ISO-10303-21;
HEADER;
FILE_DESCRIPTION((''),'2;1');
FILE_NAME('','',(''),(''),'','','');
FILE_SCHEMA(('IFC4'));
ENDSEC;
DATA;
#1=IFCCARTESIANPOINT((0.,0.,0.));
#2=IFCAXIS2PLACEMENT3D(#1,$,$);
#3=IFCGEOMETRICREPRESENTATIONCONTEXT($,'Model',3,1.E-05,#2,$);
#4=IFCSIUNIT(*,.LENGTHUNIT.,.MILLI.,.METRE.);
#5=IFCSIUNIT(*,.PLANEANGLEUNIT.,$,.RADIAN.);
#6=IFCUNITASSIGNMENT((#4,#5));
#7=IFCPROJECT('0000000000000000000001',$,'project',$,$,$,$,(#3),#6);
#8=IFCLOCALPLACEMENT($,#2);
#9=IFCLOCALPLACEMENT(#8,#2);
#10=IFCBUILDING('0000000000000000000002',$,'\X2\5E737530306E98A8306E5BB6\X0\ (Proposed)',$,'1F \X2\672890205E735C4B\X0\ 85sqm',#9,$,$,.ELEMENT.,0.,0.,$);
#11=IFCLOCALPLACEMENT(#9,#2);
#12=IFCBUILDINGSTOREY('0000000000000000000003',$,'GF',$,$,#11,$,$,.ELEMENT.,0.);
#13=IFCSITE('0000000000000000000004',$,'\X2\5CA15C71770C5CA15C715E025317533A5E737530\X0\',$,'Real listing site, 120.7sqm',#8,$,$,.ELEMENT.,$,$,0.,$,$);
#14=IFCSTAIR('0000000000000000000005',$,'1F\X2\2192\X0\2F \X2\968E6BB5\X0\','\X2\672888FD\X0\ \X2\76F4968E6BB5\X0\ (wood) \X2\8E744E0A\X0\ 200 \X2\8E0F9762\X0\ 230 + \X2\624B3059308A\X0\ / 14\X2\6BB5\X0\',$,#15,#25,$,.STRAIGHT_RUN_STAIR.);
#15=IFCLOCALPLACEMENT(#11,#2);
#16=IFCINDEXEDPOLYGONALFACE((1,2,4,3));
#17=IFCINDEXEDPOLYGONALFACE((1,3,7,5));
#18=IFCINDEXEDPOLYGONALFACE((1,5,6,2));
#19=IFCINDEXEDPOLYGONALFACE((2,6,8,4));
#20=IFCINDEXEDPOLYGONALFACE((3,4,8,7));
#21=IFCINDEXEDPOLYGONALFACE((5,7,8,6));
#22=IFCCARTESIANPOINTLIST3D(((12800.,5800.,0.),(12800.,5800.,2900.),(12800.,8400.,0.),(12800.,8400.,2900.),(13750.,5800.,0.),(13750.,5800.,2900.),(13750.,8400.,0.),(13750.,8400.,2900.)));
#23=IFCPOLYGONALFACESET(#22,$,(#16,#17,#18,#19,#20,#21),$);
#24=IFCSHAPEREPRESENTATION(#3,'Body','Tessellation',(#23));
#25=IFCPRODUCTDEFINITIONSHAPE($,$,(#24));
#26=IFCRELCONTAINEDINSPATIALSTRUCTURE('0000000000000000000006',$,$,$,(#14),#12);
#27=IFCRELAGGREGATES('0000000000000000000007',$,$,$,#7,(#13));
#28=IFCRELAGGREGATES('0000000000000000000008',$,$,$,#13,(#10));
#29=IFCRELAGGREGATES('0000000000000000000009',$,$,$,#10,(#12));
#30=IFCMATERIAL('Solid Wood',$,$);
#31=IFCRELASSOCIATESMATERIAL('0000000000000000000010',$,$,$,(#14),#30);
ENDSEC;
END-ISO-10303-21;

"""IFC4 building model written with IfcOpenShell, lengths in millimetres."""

from ifc_helpers import new_model, si_unit, frame, frame_2d, origin, place, context, project, spatial, rectangle, extrude, material, element, save


model = new_model("IFC4")

# Units and contexts
model_context = context("Model", 3, precision=1e-05, world=origin())
ifc_project = project(units=[si_unit("LENGTHUNIT", "METRE", prefix="MILLI"), si_unit("PLANEANGLEUNIT", "RADIAN")], contexts=[model_context])

# Site, building, storey
site_placement = place(None, origin())
site = spatial("IfcSite", under=ifc_project, at=site_placement, Name="岡山県岡山市北区平田", ObjectType="Real listing site, 120.7sqm", CompositionType="ELEMENT", RefElevation=0.0)
building_placement = place(site_placement, origin())
building = spatial("IfcBuilding", under=site, at=building_placement, Name="平田の風の家 (Proposed)", ObjectType="1F 木造平屋 85sqm", CompositionType="ELEMENT", ElevationOfRefHeight=0.0, ElevationOfTerrain=0.0)
storey_placement = place(building_placement, origin())
storey = spatial("IfcBuildingStorey", under=building, at=storey_placement, Name="GF", CompositionType="ELEMENT", Elevation=0.0)

# Shared definitions
ifc_material_1 = material(Name="Solid Wood")

# Stair
stair_placement = place(storey_placement, frame((6400.0, 2900.0, 0.0)))
element("IfcStair", 1, at=stair_placement, inside=storey, material=ifc_material_1, Name="1F→2F 階段", Description="木製 直階段 (wood) 蹴上 200 踏面 230 + 手すり / 14段", PredefinedType="STRAIGHT_RUN_STAIR", context=model_context, shape_type="SweptSolid", body=[
    extrude(rectangle(XDim=950.0, YDim=2600.0, at=frame_2d((475.0, 1300.0))), frame((6400.0, 2900.0, 0.0)), (0.0, 0.0, 1.0), 2900.0),
])

save(model, "model.ifc")
